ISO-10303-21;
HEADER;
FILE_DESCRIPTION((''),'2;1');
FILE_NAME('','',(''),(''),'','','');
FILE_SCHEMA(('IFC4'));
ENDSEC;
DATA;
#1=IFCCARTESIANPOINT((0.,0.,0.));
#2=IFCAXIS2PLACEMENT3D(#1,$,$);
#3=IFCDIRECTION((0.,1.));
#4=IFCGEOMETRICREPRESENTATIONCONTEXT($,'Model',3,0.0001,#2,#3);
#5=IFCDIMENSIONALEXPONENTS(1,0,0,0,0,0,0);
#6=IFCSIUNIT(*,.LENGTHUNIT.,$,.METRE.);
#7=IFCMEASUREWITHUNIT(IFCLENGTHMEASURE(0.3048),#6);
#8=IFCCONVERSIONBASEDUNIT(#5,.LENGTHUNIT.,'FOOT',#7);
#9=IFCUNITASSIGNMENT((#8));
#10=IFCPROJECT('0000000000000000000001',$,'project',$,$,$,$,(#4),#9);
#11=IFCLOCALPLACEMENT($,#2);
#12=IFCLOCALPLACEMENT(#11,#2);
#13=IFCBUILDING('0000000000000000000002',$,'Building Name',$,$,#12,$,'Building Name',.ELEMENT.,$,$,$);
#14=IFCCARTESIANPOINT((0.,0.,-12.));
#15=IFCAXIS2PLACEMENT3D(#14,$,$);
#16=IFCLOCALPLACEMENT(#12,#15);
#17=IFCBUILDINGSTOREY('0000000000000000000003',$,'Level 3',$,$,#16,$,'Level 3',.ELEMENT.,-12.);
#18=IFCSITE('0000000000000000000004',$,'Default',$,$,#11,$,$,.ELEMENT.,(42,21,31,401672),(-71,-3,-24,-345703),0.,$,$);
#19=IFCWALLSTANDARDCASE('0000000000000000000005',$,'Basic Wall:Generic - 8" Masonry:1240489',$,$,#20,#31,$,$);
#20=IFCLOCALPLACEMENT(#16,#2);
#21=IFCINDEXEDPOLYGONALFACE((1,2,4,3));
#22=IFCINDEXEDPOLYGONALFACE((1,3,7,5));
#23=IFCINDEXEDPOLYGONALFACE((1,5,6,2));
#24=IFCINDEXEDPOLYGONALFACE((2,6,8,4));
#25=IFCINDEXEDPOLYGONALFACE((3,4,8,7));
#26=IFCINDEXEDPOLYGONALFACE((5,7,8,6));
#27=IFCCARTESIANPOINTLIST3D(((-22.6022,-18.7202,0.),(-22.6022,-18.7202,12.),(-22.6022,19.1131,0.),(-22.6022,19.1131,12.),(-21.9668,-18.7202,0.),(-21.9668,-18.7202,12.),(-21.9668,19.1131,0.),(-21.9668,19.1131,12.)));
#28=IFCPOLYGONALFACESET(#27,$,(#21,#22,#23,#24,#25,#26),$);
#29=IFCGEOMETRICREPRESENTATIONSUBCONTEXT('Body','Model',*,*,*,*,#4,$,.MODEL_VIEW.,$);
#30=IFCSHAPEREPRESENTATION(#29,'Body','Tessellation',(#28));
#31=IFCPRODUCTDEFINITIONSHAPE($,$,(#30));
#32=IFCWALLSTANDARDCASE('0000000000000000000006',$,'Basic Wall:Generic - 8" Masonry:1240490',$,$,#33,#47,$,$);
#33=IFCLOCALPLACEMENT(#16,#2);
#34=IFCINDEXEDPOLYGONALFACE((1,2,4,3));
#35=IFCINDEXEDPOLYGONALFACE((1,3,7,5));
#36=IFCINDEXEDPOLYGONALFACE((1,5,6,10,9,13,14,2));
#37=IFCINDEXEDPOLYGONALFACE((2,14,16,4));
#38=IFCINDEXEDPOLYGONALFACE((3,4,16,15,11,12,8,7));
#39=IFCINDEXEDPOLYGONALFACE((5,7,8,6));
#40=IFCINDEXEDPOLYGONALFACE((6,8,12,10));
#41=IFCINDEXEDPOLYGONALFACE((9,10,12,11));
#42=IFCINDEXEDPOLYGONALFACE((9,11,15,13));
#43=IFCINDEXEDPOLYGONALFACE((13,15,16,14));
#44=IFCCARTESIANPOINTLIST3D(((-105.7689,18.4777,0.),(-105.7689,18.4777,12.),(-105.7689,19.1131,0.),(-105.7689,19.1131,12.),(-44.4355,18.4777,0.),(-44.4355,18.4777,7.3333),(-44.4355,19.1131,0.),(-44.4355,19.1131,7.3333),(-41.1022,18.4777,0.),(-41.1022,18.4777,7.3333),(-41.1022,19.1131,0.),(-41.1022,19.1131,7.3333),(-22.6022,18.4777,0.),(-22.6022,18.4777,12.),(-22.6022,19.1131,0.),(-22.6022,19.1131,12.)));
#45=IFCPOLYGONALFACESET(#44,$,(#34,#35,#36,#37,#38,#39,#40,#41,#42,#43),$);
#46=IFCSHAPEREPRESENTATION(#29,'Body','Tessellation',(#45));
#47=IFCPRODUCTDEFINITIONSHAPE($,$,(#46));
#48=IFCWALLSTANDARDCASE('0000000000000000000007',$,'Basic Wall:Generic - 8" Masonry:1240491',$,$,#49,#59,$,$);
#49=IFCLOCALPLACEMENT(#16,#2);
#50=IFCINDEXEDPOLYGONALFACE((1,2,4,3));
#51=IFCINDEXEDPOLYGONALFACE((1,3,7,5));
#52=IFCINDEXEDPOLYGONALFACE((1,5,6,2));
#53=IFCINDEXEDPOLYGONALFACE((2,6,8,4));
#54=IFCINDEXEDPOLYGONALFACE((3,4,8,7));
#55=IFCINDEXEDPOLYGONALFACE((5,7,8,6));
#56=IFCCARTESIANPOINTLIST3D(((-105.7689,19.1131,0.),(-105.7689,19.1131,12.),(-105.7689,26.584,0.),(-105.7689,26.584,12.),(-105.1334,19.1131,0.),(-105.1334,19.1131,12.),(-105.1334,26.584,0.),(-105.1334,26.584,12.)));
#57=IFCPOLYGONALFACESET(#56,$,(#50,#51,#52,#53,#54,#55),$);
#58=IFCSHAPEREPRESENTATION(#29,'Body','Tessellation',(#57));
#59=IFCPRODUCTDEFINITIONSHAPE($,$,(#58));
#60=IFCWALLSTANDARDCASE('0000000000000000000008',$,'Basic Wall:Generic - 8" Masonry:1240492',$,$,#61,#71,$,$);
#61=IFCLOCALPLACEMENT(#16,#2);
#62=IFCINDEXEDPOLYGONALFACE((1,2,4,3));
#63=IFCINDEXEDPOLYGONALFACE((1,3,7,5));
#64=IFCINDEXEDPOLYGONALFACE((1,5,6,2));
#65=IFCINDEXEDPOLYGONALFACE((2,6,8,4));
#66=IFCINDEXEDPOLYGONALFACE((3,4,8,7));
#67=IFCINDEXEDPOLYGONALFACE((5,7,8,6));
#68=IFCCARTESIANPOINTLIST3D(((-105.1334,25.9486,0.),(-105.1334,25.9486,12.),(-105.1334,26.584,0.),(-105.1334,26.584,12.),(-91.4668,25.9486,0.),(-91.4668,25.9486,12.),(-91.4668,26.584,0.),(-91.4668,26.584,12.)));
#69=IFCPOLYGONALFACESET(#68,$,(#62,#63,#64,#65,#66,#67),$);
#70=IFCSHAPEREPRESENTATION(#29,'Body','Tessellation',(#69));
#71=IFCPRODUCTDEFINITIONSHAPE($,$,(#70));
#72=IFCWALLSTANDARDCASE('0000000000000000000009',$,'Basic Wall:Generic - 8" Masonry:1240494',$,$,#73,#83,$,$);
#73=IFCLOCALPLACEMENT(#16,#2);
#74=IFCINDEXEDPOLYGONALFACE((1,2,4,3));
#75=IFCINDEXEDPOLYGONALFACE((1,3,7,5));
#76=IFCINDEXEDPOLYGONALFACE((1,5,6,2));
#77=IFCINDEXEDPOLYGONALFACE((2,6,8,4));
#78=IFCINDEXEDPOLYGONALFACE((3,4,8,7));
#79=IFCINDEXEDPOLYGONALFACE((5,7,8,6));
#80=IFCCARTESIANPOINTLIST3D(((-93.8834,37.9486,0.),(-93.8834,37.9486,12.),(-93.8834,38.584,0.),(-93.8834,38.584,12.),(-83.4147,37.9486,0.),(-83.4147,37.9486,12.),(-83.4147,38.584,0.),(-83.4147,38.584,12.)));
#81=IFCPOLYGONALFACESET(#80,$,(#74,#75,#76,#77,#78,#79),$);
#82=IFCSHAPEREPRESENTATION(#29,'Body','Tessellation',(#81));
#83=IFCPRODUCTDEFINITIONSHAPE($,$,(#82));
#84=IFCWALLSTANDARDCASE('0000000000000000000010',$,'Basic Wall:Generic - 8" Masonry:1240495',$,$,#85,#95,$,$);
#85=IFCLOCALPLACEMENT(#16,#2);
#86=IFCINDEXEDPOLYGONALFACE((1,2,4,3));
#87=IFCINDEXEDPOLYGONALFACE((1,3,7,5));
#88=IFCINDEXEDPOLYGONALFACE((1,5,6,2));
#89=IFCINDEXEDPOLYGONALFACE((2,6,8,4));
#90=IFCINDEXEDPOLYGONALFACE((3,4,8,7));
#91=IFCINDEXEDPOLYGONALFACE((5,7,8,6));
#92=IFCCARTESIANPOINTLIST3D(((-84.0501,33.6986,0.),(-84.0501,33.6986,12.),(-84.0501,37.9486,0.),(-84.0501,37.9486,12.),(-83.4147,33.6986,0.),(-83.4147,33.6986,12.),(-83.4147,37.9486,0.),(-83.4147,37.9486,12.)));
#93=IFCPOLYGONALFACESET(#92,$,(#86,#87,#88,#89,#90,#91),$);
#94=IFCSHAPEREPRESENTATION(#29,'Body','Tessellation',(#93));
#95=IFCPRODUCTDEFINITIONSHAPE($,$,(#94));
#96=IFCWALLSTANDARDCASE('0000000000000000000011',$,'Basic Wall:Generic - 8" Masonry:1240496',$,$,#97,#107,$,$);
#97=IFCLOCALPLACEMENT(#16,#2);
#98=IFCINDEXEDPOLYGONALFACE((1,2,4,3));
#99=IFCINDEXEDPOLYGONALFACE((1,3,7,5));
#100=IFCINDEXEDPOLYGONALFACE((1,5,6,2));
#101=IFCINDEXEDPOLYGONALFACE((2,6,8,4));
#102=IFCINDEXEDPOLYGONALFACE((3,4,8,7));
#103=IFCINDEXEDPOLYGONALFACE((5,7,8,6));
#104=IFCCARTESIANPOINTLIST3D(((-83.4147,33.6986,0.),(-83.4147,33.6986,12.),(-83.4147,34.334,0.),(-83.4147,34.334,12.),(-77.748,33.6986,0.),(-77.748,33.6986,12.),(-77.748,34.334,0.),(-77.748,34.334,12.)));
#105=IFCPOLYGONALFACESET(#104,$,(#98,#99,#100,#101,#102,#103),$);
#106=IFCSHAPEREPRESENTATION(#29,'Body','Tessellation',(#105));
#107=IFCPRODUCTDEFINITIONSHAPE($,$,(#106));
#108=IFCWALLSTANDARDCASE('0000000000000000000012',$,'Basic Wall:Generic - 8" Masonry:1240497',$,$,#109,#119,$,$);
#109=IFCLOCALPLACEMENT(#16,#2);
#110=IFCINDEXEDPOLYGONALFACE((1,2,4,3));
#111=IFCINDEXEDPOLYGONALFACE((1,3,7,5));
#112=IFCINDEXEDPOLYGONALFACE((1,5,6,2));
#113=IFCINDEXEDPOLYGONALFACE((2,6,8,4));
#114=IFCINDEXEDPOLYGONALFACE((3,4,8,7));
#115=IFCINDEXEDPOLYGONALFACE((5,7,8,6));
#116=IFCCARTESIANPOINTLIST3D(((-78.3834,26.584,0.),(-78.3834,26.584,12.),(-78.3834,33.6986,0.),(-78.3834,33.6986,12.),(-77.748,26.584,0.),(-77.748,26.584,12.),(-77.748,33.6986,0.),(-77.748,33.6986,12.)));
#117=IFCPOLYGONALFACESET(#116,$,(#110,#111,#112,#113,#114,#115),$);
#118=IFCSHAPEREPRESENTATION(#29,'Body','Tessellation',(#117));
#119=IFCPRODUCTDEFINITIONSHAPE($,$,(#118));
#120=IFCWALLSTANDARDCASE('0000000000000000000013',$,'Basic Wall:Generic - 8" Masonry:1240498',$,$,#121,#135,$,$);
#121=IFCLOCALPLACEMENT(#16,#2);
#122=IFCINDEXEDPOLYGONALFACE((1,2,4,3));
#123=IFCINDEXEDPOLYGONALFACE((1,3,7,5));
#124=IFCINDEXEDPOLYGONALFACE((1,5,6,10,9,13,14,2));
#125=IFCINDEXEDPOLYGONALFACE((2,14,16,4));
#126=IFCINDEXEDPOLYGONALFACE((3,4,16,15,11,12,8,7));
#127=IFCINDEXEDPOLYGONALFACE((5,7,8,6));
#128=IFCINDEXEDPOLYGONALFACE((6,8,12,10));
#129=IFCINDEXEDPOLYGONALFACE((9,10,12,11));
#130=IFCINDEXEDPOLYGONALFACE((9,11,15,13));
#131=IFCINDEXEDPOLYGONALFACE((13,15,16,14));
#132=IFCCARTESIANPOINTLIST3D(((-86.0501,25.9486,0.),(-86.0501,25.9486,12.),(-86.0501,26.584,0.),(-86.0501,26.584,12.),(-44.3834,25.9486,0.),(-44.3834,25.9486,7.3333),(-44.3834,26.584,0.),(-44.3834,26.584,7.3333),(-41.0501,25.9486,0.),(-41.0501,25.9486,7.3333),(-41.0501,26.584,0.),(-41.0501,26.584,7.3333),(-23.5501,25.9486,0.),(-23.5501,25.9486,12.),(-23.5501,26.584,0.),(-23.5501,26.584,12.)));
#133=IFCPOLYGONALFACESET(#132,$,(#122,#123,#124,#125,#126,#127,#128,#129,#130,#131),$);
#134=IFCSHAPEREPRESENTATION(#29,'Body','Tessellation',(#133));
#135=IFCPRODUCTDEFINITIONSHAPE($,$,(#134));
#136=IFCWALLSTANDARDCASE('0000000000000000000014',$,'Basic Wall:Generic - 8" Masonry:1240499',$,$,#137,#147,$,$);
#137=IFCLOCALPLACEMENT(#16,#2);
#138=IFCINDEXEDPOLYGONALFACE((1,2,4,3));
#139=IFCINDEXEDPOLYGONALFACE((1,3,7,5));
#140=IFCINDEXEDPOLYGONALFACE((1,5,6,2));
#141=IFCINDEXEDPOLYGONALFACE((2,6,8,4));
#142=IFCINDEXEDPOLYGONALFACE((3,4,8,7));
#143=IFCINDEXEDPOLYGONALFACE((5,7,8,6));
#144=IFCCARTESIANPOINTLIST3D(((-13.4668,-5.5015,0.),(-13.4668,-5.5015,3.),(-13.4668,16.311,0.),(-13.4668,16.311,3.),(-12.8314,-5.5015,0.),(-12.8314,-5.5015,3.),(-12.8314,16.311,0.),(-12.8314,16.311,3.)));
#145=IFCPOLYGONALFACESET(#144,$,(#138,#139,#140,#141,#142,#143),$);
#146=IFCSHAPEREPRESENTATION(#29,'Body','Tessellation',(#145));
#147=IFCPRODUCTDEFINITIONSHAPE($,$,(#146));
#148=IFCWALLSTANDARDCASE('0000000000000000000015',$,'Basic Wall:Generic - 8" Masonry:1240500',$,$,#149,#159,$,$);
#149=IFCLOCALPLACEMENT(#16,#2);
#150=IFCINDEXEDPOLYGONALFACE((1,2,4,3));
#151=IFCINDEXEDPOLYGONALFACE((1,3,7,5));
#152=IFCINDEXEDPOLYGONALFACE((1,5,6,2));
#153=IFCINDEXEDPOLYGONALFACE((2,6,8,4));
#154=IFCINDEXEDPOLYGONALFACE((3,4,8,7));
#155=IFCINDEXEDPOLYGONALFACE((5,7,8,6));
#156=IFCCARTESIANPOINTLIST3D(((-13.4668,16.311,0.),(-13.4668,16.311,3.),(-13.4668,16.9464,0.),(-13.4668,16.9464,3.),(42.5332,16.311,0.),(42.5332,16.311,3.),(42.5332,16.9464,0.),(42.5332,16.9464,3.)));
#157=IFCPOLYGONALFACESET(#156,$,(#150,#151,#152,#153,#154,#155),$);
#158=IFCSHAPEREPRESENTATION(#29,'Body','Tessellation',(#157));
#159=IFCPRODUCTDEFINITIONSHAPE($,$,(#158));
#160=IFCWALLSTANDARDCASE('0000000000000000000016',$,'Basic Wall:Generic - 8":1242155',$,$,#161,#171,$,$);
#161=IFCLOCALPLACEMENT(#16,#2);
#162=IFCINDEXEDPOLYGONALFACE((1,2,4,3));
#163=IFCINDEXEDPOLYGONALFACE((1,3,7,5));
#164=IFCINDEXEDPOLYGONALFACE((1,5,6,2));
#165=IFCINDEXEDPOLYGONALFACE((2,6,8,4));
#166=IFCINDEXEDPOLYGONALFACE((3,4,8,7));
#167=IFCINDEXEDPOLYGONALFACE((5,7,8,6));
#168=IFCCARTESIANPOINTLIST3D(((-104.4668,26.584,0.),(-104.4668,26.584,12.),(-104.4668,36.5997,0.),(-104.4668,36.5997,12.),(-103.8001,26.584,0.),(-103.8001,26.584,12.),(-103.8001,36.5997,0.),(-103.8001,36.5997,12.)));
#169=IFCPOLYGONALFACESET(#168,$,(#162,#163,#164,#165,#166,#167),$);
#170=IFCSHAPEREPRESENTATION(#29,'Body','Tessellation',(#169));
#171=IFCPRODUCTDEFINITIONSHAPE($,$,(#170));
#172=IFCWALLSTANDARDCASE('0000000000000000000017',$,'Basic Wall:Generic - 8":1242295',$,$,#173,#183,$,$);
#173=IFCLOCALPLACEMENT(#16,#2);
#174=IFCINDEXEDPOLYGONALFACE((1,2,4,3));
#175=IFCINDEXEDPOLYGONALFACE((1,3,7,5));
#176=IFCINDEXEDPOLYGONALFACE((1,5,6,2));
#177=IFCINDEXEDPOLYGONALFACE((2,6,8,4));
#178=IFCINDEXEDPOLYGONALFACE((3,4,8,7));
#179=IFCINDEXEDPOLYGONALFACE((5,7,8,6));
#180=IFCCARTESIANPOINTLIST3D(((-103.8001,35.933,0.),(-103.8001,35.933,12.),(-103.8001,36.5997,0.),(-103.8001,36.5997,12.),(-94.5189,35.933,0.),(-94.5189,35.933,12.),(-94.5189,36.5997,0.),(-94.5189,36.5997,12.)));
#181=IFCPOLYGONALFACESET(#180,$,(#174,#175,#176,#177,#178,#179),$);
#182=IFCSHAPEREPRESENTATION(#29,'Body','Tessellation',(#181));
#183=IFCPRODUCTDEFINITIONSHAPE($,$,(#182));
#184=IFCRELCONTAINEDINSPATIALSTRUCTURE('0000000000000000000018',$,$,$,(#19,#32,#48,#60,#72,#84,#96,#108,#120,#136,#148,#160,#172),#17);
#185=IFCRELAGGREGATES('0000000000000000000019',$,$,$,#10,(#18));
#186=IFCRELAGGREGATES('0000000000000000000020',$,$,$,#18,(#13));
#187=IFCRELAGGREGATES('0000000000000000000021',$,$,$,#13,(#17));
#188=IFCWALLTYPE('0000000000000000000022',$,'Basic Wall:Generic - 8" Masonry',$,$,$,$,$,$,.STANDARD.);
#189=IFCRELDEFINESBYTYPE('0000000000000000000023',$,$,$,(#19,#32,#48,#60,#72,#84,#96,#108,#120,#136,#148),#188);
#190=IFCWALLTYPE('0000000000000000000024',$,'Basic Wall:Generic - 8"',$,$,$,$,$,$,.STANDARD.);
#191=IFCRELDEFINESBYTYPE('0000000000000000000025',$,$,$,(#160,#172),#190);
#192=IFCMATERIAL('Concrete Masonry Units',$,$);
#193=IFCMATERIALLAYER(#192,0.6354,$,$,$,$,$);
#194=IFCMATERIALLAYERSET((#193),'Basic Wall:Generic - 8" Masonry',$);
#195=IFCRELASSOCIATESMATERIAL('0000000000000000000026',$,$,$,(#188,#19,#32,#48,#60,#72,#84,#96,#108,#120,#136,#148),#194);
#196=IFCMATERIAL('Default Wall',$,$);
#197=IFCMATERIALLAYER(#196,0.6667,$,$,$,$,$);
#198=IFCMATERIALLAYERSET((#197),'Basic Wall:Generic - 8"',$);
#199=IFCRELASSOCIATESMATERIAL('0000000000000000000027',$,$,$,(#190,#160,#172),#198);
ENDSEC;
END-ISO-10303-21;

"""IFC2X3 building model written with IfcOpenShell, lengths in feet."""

from ifc_helpers import new_model, entity, si_unit, converted_unit, direction, frame, frame_2d, origin, place, context, subcontext, project, spatial, rectangle, extrude, material, layer, layer_set, layer_usage, type_object, element, save


model = new_model("IFC2X3")

# Units and contexts
model_context = context("Model", 3, precision=0.0001, world=origin(), true_north=direction((0.0, 1.0)))
body_context = subcontext(model_context, "Body", "Model", "MODEL_VIEW")
ifc_project = project(units=[converted_unit("LENGTHUNIT", "FOOT", entity("IfcLengthMeasure", 0.3048), si_unit("LENGTHUNIT", "METRE"), dimensions=[1, 0, 0, 0, 0, 0, 0])], contexts=[model_context])

# Site, building, storey
site_placement = place(None, origin())
site = spatial("IfcSite", under=ifc_project, at=site_placement, Name="Default", CompositionType="ELEMENT", RefLatitude=(42, 21, 31, 401672), RefLongitude=(-71, -3, -24, -345703), RefElevation=0.0)
building_placement = place(site_placement, origin())
building = spatial("IfcBuilding", under=site, at=building_placement, Name="Building Name", LongName="Building Name", CompositionType="ELEMENT")
storey_placement = place(building_placement, frame((0.0, 0.0, -12.0)))
storey = spatial("IfcBuildingStorey", under=building, at=storey_placement, Name="Level 3", LongName="Level 3", CompositionType="ELEMENT", Elevation=-12.0)

# Wall
ifc_material_1 = material(Name="Concrete Masonry Units")
ifc_layer_1 = layer(ifc_material_1, 0.6354)
ifc_layer_set_1 = layer_set([ifc_layer_1], Name="Basic Wall:Generic - 8\" Masonry")
ifc_layer_usage_1 = layer_usage(ifc_layer_set_1, "AXIS2", "NEGATIVE", 0.3177)
wall_type_1 = type_object("IfcWallType", Name="Basic Wall:Generic - 8\" Masonry", PredefinedType="STANDARD", material=ifc_layer_set_1)
wall_1_placement = place(storey_placement, frame((-22.2845, 19.1131, 0.0), z_axis=(0.0, 0.0, 1.0), x_axis=(0.0, -1.0, 0.0)))
element("IfcWallStandardCase", 1, at=wall_1_placement, inside=storey, type_object=wall_type_1, material=ifc_layer_usage_1, Name="Basic Wall:Generic - 8\" Masonry:1240489", context=body_context, shape_type="SweptSolid", body=[
    extrude(rectangle(XDim=37.8333, YDim=0.6354, at=frame_2d((18.9167, 0.0), x_axis=(-1.0, 0.0))), origin(), (0.0, 0.0, 1.0), 12.0),
])

# Wall, opening
ifc_layer_usage_2 = layer_usage(ifc_layer_set_1, "AXIS2", "NEGATIVE", 0.3177)
wall_2_placement = place(storey_placement, frame((-22.6022, 18.7954, 0.0), z_axis=(0.0, 0.0, 1.0), x_axis=(-1.0, 0.0, 0.0)))
wall_2 = element("IfcWallStandardCase", 2, at=wall_2_placement, inside=storey, type_object=wall_type_1, material=ifc_layer_usage_2, Name="Basic Wall:Generic - 8\" Masonry:1240490", context=body_context, shape_type="SweptSolid", body=[
    extrude(rectangle(XDim=83.1667, YDim=0.6354, at=frame_2d((41.5833, 0.0), x_axis=(1.0, 0.0))), origin(), (0.0, 0.0, 1.0), 12.0),
])
opening_1_placement = place(wall_2_placement, frame((18.5, -0.3177, 0.0)))
element("IfcOpeningElement", 3, at=opening_1_placement, cuts=wall_2, ObjectType="Opening", context=body_context, shape_type="SweptSolid", body=[
    extrude(rectangle(XDim=7.3333, YDim=3.3333, at=frame_2d((3.6667, 1.6667), x_axis=(1.0, 0.0))), frame((0.0, 0.0, 0.0), z_axis=(0.0, 1.0, 0.0), x_axis=(0.0, 0.0, 1.0)), (0.0, 0.0, 1.0), 0.6354),
])

# Walls
ifc_layer_usage_3 = layer_usage(ifc_layer_set_1, "AXIS2", "NEGATIVE", 0.3177)
wall_3_placement = place(storey_placement, frame((-105.4511, 19.1131, 0.0), z_axis=(0.0, 0.0, 1.0), x_axis=(0.0, 1.0, 0.0)))
element("IfcWallStandardCase", 4, at=wall_3_placement, inside=storey, type_object=wall_type_1, material=ifc_layer_usage_3, Name="Basic Wall:Generic - 8\" Masonry:1240491", context=body_context, shape_type="SweptSolid", body=[
    extrude(rectangle(XDim=7.4709, YDim=0.6354, at=frame_2d((3.7355, 0.0), x_axis=(-1.0, 0.0))), origin(), (0.0, 0.0, 1.0), 12.0),
])
ifc_layer_usage_4 = layer_usage(ifc_layer_set_1, "AXIS2", "NEGATIVE", 0.3177)
wall_4_placement = place(storey_placement, frame((-105.1334, 26.2663, 0.0)))
element("IfcWallStandardCase", 5, at=wall_4_placement, inside=storey, type_object=wall_type_1, material=ifc_layer_usage_4, Name="Basic Wall:Generic - 8\" Masonry:1240492", context=body_context, shape_type="SweptSolid", body=[
    extrude(rectangle(XDim=13.6667, YDim=0.6354, at=frame_2d((6.8333, 0.0), x_axis=(-1.0, 0.0))), origin(), (0.0, 0.0, 1.0), 12.0),
])

# Walls
ifc_layer_usage_5 = layer_usage(ifc_layer_set_1, "AXIS2", "NEGATIVE", 0.3177)
wall_5_placement = place(storey_placement, frame((-93.8834, 38.2663, 0.0)))
element("IfcWallStandardCase", 6, at=wall_5_placement, inside=storey, type_object=wall_type_1, material=ifc_layer_usage_5, Name="Basic Wall:Generic - 8\" Masonry:1240494", context=body_context, shape_type="SweptSolid", body=[
    extrude(rectangle(XDim=10.4687, YDim=0.6354, at=frame_2d((5.2344, 0.0), x_axis=(-1.0, 0.0))), origin(), (0.0, 0.0, 1.0), 12.0),
])
ifc_layer_usage_6 = layer_usage(ifc_layer_set_1, "AXIS2", "NEGATIVE", 0.3177)
wall_6_placement = place(storey_placement, frame((-83.7324, 37.9486, 0.0), z_axis=(0.0, 0.0, 1.0), x_axis=(0.0, -1.0, 0.0)))
element("IfcWallStandardCase", 7, at=wall_6_placement, inside=storey, type_object=wall_type_1, material=ifc_layer_usage_6, Name="Basic Wall:Generic - 8\" Masonry:1240495", context=body_context, shape_type="SweptSolid", body=[
    extrude(rectangle(XDim=4.25, YDim=0.6354, at=frame_2d((2.125, 0.0), x_axis=(-1.0, 0.0))), origin(), (0.0, 0.0, 1.0), 12.0),
])
ifc_layer_usage_7 = layer_usage(ifc_layer_set_1, "AXIS2", "NEGATIVE", 0.3177)
wall_7_placement = place(storey_placement, frame((-83.4147, 34.0163, 0.0)))
element("IfcWallStandardCase", 8, at=wall_7_placement, inside=storey, type_object=wall_type_1, material=ifc_layer_usage_7, Name="Basic Wall:Generic - 8\" Masonry:1240496", context=body_context, shape_type="SweptSolid", body=[
    extrude(rectangle(XDim=5.6667, YDim=0.6354, at=frame_2d((2.8333, 0.0), x_axis=(-1.0, 0.0))), origin(), (0.0, 0.0, 1.0), 12.0),
])
ifc_layer_usage_8 = layer_usage(ifc_layer_set_1, "AXIS2", "NEGATIVE", 0.3177)
wall_8_placement = place(storey_placement, frame((-78.0657, 33.6986, 0.0), z_axis=(0.0, 0.0, 1.0), x_axis=(0.0, -1.0, 0.0)))
element("IfcWallStandardCase", 9, at=wall_8_placement, inside=storey, type_object=wall_type_1, material=ifc_layer_usage_8, Name="Basic Wall:Generic - 8\" Masonry:1240497", context=body_context, shape_type="SweptSolid", body=[
    extrude(rectangle(XDim=7.1146, YDim=0.6354, at=frame_2d((3.5573, 0.0), x_axis=(1.0, 0.0))), origin(), (0.0, 0.0, 1.0), 12.0),
])

# Wall, opening
ifc_layer_usage_9 = layer_usage(ifc_layer_set_1, "AXIS2", "NEGATIVE", 0.3177)
wall_9_placement = place(storey_placement, frame((-23.5501, 26.2663, 0.0), z_axis=(0.0, 0.0, 1.0), x_axis=(-1.0, 0.0, 0.0)))
wall_9 = element("IfcWallStandardCase", 10, at=wall_9_placement, inside=storey, type_object=wall_type_1, material=ifc_layer_usage_9, Name="Basic Wall:Generic - 8\" Masonry:1240498", context=body_context, shape_type="SweptSolid", body=[
    extrude(rectangle(XDim=62.5, YDim=0.6354, at=frame_2d((31.25, 0.0), x_axis=(1.0, 0.0))), origin(), (0.0, 0.0, 1.0), 12.0),
])
opening_2_placement = place(wall_9_placement, frame((20.8333, 0.3177, 0.0)))
element("IfcOpeningElement", 11, at=opening_2_placement, cuts=wall_9, ObjectType="Opening", context=body_context, shape_type="SweptSolid", body=[
    extrude(rectangle(XDim=7.3333, YDim=3.3333, at=frame_2d((3.6667, 1.6667), x_axis=(1.0, 0.0))), frame((0.0, 0.0, 0.0), z_axis=(0.0, -1.0, 0.0), x_axis=(0.0, 0.0, 1.0)), (0.0, 0.0, 1.0), 0.6354),
])

# Walls
ifc_layer_usage_10 = layer_usage(ifc_layer_set_1, "AXIS2", "NEGATIVE", 0.3177)
wall_10_placement = place(storey_placement, frame((-13.1491, -5.5015, 0.0), z_axis=(0.0, 0.0, 1.0), x_axis=(0.0, 1.0, 0.0)))
element("IfcWallStandardCase", 12, at=wall_10_placement, inside=storey, type_object=wall_type_1, material=ifc_layer_usage_10, Name="Basic Wall:Generic - 8\" Masonry:1240499", context=body_context, shape_type="SweptSolid", body=[
    extrude(rectangle(XDim=21.8125, YDim=0.6354, at=frame_2d((10.9063, 0.0), x_axis=(-1.0, 0.0))), origin(), (0.0, 0.0, 1.0), 3.0),
])
ifc_layer_usage_11 = layer_usage(ifc_layer_set_1, "AXIS2", "NEGATIVE", 0.3177)
wall_11_placement = place(storey_placement, frame((-13.4668, 16.6287, 0.0)))
element("IfcWallStandardCase", 13, at=wall_11_placement, inside=storey, type_object=wall_type_1, material=ifc_layer_usage_11, Name="Basic Wall:Generic - 8\" Masonry:1240500", context=body_context, shape_type="SweptSolid", body=[
    extrude(rectangle(XDim=56.0, YDim=0.6354, at=frame_2d((28.0, 0.0), x_axis=(-1.0, 0.0))), origin(), (0.0, 0.0, 1.0), 3.0),
])
ifc_material_2 = material(Name="Default Wall")
ifc_layer_2 = layer(ifc_material_2, 0.6667)
ifc_layer_set_2 = layer_set([ifc_layer_2], Name="Basic Wall:Generic - 8\"")
ifc_layer_usage_12 = layer_usage(ifc_layer_set_2, "AXIS2", "NEGATIVE", 0.3333)
wall_type_2 = type_object("IfcWallType", Name="Basic Wall:Generic - 8\"", PredefinedType="STANDARD", material=ifc_layer_set_2)
wall_12_placement = place(storey_placement, frame((-104.1334, 26.584, 0.0), z_axis=(0.0, 0.0, 1.0), x_axis=(0.0, 1.0, 0.0)))
element("IfcWallStandardCase", 14, at=wall_12_placement, inside=storey, type_object=wall_type_2, material=ifc_layer_usage_12, Name="Basic Wall:Generic - 8\":1242155", context=body_context, shape_type="SweptSolid", body=[
    extrude(rectangle(XDim=10.0156, YDim=0.6667, at=frame_2d((5.0078, 0.0), x_axis=(-1.0, 0.0))), origin(), (0.0, 0.0, 1.0), 12.0),
])
ifc_layer_usage_13 = layer_usage(ifc_layer_set_2, "AXIS2", "POSITIVE", -0.3333)
wall_13_placement = place(storey_placement, frame((-103.8001, 36.2663, 0.0)))
element("IfcWallStandardCase", 15, at=wall_13_placement, inside=storey, type_object=wall_type_2, material=ifc_layer_usage_13, Name="Basic Wall:Generic - 8\":1242295", context=body_context, shape_type="SweptSolid", body=[
    extrude(rectangle(XDim=9.2812, YDim=0.6667, at=frame_2d((4.6406, 0.0), x_axis=(-1.0, 0.0))), origin(), (0.0, 0.0, 1.0), 12.0),
])

save(model, "model.ifc")
